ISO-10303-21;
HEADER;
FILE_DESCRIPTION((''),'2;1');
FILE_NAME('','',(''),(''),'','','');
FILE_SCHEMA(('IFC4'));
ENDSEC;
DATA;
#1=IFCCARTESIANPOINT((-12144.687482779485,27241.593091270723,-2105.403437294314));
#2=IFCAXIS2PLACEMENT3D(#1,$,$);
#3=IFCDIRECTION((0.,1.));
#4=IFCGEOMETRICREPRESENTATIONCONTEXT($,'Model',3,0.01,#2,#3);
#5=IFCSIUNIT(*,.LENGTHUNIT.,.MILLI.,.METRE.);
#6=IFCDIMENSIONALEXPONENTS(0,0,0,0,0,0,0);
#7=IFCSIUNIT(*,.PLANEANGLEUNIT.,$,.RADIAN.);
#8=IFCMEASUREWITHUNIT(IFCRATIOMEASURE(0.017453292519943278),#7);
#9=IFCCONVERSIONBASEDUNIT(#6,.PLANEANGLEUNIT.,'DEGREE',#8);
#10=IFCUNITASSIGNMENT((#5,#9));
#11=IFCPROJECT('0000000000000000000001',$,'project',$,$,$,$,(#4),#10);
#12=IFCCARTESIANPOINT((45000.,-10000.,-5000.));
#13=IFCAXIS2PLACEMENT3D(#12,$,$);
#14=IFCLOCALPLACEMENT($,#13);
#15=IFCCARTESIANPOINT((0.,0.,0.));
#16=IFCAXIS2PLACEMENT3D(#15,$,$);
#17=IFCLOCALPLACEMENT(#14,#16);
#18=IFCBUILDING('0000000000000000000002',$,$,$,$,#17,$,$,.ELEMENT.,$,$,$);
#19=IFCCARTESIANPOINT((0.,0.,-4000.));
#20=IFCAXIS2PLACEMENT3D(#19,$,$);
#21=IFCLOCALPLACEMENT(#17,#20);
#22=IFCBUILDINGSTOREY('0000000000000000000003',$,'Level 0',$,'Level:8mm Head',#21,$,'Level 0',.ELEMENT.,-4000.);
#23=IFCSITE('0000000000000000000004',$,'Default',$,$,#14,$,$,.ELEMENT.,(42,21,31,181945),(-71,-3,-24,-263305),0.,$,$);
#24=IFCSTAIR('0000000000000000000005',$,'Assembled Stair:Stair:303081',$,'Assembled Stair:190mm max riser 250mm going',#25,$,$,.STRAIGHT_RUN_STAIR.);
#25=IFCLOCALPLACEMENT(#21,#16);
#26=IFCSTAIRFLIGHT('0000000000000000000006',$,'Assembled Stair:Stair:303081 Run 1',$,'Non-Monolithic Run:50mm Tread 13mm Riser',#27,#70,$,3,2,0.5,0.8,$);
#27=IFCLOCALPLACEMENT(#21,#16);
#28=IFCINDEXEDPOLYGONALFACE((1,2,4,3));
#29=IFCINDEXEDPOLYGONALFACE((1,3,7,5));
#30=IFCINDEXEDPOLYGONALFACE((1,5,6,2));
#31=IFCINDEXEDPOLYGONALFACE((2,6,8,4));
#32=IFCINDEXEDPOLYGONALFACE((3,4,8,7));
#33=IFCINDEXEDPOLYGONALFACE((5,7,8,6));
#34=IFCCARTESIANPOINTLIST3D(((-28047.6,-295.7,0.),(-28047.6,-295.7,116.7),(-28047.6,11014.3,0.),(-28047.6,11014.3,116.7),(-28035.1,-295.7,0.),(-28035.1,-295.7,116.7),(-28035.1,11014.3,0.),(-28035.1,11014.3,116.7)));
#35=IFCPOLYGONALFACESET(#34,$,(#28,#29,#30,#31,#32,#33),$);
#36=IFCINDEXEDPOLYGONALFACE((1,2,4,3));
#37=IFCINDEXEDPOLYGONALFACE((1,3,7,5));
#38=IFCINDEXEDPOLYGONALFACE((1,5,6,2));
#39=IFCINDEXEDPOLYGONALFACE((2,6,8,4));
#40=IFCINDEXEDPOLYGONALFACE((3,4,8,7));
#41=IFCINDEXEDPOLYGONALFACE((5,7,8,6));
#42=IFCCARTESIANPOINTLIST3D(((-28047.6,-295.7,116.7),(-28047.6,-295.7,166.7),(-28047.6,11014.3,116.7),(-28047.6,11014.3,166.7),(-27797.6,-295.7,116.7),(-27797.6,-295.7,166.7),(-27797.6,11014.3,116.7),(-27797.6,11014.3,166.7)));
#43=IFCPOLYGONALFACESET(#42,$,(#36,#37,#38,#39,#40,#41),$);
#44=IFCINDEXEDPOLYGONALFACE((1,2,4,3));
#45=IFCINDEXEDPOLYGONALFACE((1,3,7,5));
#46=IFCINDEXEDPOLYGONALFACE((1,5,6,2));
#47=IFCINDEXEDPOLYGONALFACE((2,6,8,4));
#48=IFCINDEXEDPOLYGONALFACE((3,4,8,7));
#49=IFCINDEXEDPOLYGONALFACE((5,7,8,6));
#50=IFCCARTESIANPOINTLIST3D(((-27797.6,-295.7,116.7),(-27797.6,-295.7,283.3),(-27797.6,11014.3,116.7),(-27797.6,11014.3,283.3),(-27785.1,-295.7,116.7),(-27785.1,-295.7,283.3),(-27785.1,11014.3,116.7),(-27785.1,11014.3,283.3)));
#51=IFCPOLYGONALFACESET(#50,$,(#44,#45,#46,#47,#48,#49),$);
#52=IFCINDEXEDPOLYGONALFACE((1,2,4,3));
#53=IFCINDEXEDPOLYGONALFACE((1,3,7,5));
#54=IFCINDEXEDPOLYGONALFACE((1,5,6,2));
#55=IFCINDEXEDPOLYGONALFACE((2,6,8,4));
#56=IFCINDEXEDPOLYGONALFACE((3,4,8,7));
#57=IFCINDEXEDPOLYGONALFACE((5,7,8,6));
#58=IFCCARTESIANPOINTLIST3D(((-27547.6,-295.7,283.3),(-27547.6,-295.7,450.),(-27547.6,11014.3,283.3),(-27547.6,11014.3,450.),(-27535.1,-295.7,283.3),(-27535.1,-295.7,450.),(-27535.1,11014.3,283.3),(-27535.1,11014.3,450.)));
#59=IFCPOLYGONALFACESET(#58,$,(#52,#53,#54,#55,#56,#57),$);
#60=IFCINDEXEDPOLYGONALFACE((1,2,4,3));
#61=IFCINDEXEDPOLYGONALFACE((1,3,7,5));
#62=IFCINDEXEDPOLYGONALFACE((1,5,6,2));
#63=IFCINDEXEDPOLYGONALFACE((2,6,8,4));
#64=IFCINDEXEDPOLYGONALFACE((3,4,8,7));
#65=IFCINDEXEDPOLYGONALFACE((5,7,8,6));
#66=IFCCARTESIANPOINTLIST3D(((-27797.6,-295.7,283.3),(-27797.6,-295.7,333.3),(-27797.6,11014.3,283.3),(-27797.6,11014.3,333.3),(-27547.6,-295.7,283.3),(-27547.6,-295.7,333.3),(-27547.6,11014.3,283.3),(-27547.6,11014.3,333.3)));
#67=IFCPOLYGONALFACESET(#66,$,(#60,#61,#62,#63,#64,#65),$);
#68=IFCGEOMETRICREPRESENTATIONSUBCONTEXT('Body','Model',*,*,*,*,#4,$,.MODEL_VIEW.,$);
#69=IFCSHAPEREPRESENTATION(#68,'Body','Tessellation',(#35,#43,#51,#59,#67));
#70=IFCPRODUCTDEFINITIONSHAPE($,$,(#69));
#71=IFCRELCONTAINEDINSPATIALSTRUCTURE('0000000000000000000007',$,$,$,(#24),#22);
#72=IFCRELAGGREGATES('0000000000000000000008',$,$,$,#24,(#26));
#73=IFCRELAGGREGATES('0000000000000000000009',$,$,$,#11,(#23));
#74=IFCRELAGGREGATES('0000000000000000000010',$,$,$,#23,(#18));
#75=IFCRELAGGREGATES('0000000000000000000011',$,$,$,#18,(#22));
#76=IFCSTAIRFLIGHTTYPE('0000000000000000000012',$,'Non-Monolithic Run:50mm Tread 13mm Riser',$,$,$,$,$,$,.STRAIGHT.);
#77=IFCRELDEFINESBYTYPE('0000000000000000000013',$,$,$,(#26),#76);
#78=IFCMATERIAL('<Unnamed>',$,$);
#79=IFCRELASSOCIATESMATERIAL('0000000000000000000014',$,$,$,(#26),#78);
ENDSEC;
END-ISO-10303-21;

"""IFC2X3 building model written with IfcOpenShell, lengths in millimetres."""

from ifc_helpers import new_model, entity, si_unit, converted_unit, direction, frame, frame_2d, origin, place, context, subcontext, project, spatial, rectangle, extrude, material, type_object, element, aggregate, save


model = new_model("IFC2X3")

# Units and contexts
model_context = context("Model", 3, precision=0.01, world=frame((-12144.687482779485, 27241.593091270723, -2105.403437294314)), true_north=direction((0.0, 1.0)))
body_context = subcontext(model_context, "Body", "Model", "MODEL_VIEW")
ifc_project = project(units=[si_unit("LENGTHUNIT", "METRE", prefix="MILLI"), converted_unit("PLANEANGLEUNIT", "DEGREE", entity("IfcRatioMeasure", 0.017453292519943278), si_unit("PLANEANGLEUNIT", "RADIAN"), dimensions=[0, 0, 0, 0, 0, 0, 0])], contexts=[model_context])

# Site, building, storey
site_placement = place(None, frame((45000.0, -10000.0, -5000.0)))
site = spatial("IfcSite", under=ifc_project, at=site_placement, Name="Default", CompositionType="ELEMENT", RefLatitude=(42, 21, 31, 181945), RefLongitude=(-71, -3, -24, -263305), RefElevation=0.0)
building_placement = place(site_placement, origin())
building = spatial("IfcBuilding", under=site, at=building_placement, CompositionType="ELEMENT")
storey_placement = place(building_placement, frame((0.0, 0.0, -4000.0)))
storey = spatial("IfcBuildingStorey", under=building, at=storey_placement, Name="Level 0", ObjectType="Level:8mm Head", LongName="Level 0", CompositionType="ELEMENT", Elevation=-4000.0)

# Stair
stair_placement = place(storey_placement, origin())
stair = element("IfcStair", 1, at=stair_placement, inside=storey, Name="Assembled Stair:Stair:303081", ObjectType="Assembled Stair:190mm max riser 250mm going", ShapeType="STRAIGHT_RUN_STAIR")
ifc_material_1 = material(Name="<Unnamed>")

# Stair flight
stair_flight_type = type_object("IfcStairFlightType", Name="Non-Monolithic Run:50mm Tread 13mm Riser", PredefinedType="STRAIGHT")
stair_flight_placement = place(stair_placement, origin())
stair_flight = element("IfcStairFlight", 2, at=stair_flight_placement, type_object=stair_flight_type, material=ifc_material_1, Name="Assembled Stair:Stair:303081 Run 1", ObjectType="Non-Monolithic Run:50mm Tread 13mm Riser", NumberOfRiser=3, NumberOfTreads=2, RiserHeight=0.5, TreadLength=0.8, context=body_context, shape_type="SweptSolid", body=[
    extrude(rectangle(XDim=11310.0, YDim=12.5, at=frame_2d((0.0, 0.0), x_axis=(1.0, 0.0))), frame((-28041.4, 5359.3, 0.0), z_axis=(0.0, 0.0, 1.0), x_axis=(0.0, 1.0, 0.0)), (0.0, 0.0, 1.0), 116.7),
    extrude(rectangle(XDim=250.0, YDim=11310.0, at=frame_2d((0.0, 0.0), x_axis=(1.0, 0.0))), frame((-27922.6, 5359.3, 116.7), z_axis=(0.0, 0.0, 1.0), x_axis=(-1.0, 0.0, 0.0)), (0.0, 0.0, 1.0), 50.0),
    extrude(rectangle(XDim=11310.0, YDim=12.5, at=frame_2d((0.0, 0.0), x_axis=(1.0, 0.0))), frame((-27791.4, 5359.3, 116.7), z_axis=(0.0, 0.0, 1.0), x_axis=(0.0, 1.0, 0.0)), (0.0, 0.0, 1.0), 166.7),
    extrude(rectangle(XDim=11310.0, YDim=12.5, at=frame_2d((0.0, 0.0), x_axis=(1.0, 0.0))), frame((-27541.4, 5359.3, 283.3), z_axis=(0.0, 0.0, 1.0), x_axis=(0.0, 1.0, 0.0)), (0.0, 0.0, 1.0), 166.7),
    extrude(rectangle(XDim=250.0, YDim=11310.0, at=frame_2d((0.0, 0.0), x_axis=(1.0, 0.0))), frame((-27672.6, 5359.3, 283.3), z_axis=(0.0, 0.0, 1.0), x_axis=(-1.0, 0.0, 0.0)), (0.0, 0.0, 1.0), 50.0),
])
aggregate(stair, [stair_flight])

save(model, "model.ifc")
